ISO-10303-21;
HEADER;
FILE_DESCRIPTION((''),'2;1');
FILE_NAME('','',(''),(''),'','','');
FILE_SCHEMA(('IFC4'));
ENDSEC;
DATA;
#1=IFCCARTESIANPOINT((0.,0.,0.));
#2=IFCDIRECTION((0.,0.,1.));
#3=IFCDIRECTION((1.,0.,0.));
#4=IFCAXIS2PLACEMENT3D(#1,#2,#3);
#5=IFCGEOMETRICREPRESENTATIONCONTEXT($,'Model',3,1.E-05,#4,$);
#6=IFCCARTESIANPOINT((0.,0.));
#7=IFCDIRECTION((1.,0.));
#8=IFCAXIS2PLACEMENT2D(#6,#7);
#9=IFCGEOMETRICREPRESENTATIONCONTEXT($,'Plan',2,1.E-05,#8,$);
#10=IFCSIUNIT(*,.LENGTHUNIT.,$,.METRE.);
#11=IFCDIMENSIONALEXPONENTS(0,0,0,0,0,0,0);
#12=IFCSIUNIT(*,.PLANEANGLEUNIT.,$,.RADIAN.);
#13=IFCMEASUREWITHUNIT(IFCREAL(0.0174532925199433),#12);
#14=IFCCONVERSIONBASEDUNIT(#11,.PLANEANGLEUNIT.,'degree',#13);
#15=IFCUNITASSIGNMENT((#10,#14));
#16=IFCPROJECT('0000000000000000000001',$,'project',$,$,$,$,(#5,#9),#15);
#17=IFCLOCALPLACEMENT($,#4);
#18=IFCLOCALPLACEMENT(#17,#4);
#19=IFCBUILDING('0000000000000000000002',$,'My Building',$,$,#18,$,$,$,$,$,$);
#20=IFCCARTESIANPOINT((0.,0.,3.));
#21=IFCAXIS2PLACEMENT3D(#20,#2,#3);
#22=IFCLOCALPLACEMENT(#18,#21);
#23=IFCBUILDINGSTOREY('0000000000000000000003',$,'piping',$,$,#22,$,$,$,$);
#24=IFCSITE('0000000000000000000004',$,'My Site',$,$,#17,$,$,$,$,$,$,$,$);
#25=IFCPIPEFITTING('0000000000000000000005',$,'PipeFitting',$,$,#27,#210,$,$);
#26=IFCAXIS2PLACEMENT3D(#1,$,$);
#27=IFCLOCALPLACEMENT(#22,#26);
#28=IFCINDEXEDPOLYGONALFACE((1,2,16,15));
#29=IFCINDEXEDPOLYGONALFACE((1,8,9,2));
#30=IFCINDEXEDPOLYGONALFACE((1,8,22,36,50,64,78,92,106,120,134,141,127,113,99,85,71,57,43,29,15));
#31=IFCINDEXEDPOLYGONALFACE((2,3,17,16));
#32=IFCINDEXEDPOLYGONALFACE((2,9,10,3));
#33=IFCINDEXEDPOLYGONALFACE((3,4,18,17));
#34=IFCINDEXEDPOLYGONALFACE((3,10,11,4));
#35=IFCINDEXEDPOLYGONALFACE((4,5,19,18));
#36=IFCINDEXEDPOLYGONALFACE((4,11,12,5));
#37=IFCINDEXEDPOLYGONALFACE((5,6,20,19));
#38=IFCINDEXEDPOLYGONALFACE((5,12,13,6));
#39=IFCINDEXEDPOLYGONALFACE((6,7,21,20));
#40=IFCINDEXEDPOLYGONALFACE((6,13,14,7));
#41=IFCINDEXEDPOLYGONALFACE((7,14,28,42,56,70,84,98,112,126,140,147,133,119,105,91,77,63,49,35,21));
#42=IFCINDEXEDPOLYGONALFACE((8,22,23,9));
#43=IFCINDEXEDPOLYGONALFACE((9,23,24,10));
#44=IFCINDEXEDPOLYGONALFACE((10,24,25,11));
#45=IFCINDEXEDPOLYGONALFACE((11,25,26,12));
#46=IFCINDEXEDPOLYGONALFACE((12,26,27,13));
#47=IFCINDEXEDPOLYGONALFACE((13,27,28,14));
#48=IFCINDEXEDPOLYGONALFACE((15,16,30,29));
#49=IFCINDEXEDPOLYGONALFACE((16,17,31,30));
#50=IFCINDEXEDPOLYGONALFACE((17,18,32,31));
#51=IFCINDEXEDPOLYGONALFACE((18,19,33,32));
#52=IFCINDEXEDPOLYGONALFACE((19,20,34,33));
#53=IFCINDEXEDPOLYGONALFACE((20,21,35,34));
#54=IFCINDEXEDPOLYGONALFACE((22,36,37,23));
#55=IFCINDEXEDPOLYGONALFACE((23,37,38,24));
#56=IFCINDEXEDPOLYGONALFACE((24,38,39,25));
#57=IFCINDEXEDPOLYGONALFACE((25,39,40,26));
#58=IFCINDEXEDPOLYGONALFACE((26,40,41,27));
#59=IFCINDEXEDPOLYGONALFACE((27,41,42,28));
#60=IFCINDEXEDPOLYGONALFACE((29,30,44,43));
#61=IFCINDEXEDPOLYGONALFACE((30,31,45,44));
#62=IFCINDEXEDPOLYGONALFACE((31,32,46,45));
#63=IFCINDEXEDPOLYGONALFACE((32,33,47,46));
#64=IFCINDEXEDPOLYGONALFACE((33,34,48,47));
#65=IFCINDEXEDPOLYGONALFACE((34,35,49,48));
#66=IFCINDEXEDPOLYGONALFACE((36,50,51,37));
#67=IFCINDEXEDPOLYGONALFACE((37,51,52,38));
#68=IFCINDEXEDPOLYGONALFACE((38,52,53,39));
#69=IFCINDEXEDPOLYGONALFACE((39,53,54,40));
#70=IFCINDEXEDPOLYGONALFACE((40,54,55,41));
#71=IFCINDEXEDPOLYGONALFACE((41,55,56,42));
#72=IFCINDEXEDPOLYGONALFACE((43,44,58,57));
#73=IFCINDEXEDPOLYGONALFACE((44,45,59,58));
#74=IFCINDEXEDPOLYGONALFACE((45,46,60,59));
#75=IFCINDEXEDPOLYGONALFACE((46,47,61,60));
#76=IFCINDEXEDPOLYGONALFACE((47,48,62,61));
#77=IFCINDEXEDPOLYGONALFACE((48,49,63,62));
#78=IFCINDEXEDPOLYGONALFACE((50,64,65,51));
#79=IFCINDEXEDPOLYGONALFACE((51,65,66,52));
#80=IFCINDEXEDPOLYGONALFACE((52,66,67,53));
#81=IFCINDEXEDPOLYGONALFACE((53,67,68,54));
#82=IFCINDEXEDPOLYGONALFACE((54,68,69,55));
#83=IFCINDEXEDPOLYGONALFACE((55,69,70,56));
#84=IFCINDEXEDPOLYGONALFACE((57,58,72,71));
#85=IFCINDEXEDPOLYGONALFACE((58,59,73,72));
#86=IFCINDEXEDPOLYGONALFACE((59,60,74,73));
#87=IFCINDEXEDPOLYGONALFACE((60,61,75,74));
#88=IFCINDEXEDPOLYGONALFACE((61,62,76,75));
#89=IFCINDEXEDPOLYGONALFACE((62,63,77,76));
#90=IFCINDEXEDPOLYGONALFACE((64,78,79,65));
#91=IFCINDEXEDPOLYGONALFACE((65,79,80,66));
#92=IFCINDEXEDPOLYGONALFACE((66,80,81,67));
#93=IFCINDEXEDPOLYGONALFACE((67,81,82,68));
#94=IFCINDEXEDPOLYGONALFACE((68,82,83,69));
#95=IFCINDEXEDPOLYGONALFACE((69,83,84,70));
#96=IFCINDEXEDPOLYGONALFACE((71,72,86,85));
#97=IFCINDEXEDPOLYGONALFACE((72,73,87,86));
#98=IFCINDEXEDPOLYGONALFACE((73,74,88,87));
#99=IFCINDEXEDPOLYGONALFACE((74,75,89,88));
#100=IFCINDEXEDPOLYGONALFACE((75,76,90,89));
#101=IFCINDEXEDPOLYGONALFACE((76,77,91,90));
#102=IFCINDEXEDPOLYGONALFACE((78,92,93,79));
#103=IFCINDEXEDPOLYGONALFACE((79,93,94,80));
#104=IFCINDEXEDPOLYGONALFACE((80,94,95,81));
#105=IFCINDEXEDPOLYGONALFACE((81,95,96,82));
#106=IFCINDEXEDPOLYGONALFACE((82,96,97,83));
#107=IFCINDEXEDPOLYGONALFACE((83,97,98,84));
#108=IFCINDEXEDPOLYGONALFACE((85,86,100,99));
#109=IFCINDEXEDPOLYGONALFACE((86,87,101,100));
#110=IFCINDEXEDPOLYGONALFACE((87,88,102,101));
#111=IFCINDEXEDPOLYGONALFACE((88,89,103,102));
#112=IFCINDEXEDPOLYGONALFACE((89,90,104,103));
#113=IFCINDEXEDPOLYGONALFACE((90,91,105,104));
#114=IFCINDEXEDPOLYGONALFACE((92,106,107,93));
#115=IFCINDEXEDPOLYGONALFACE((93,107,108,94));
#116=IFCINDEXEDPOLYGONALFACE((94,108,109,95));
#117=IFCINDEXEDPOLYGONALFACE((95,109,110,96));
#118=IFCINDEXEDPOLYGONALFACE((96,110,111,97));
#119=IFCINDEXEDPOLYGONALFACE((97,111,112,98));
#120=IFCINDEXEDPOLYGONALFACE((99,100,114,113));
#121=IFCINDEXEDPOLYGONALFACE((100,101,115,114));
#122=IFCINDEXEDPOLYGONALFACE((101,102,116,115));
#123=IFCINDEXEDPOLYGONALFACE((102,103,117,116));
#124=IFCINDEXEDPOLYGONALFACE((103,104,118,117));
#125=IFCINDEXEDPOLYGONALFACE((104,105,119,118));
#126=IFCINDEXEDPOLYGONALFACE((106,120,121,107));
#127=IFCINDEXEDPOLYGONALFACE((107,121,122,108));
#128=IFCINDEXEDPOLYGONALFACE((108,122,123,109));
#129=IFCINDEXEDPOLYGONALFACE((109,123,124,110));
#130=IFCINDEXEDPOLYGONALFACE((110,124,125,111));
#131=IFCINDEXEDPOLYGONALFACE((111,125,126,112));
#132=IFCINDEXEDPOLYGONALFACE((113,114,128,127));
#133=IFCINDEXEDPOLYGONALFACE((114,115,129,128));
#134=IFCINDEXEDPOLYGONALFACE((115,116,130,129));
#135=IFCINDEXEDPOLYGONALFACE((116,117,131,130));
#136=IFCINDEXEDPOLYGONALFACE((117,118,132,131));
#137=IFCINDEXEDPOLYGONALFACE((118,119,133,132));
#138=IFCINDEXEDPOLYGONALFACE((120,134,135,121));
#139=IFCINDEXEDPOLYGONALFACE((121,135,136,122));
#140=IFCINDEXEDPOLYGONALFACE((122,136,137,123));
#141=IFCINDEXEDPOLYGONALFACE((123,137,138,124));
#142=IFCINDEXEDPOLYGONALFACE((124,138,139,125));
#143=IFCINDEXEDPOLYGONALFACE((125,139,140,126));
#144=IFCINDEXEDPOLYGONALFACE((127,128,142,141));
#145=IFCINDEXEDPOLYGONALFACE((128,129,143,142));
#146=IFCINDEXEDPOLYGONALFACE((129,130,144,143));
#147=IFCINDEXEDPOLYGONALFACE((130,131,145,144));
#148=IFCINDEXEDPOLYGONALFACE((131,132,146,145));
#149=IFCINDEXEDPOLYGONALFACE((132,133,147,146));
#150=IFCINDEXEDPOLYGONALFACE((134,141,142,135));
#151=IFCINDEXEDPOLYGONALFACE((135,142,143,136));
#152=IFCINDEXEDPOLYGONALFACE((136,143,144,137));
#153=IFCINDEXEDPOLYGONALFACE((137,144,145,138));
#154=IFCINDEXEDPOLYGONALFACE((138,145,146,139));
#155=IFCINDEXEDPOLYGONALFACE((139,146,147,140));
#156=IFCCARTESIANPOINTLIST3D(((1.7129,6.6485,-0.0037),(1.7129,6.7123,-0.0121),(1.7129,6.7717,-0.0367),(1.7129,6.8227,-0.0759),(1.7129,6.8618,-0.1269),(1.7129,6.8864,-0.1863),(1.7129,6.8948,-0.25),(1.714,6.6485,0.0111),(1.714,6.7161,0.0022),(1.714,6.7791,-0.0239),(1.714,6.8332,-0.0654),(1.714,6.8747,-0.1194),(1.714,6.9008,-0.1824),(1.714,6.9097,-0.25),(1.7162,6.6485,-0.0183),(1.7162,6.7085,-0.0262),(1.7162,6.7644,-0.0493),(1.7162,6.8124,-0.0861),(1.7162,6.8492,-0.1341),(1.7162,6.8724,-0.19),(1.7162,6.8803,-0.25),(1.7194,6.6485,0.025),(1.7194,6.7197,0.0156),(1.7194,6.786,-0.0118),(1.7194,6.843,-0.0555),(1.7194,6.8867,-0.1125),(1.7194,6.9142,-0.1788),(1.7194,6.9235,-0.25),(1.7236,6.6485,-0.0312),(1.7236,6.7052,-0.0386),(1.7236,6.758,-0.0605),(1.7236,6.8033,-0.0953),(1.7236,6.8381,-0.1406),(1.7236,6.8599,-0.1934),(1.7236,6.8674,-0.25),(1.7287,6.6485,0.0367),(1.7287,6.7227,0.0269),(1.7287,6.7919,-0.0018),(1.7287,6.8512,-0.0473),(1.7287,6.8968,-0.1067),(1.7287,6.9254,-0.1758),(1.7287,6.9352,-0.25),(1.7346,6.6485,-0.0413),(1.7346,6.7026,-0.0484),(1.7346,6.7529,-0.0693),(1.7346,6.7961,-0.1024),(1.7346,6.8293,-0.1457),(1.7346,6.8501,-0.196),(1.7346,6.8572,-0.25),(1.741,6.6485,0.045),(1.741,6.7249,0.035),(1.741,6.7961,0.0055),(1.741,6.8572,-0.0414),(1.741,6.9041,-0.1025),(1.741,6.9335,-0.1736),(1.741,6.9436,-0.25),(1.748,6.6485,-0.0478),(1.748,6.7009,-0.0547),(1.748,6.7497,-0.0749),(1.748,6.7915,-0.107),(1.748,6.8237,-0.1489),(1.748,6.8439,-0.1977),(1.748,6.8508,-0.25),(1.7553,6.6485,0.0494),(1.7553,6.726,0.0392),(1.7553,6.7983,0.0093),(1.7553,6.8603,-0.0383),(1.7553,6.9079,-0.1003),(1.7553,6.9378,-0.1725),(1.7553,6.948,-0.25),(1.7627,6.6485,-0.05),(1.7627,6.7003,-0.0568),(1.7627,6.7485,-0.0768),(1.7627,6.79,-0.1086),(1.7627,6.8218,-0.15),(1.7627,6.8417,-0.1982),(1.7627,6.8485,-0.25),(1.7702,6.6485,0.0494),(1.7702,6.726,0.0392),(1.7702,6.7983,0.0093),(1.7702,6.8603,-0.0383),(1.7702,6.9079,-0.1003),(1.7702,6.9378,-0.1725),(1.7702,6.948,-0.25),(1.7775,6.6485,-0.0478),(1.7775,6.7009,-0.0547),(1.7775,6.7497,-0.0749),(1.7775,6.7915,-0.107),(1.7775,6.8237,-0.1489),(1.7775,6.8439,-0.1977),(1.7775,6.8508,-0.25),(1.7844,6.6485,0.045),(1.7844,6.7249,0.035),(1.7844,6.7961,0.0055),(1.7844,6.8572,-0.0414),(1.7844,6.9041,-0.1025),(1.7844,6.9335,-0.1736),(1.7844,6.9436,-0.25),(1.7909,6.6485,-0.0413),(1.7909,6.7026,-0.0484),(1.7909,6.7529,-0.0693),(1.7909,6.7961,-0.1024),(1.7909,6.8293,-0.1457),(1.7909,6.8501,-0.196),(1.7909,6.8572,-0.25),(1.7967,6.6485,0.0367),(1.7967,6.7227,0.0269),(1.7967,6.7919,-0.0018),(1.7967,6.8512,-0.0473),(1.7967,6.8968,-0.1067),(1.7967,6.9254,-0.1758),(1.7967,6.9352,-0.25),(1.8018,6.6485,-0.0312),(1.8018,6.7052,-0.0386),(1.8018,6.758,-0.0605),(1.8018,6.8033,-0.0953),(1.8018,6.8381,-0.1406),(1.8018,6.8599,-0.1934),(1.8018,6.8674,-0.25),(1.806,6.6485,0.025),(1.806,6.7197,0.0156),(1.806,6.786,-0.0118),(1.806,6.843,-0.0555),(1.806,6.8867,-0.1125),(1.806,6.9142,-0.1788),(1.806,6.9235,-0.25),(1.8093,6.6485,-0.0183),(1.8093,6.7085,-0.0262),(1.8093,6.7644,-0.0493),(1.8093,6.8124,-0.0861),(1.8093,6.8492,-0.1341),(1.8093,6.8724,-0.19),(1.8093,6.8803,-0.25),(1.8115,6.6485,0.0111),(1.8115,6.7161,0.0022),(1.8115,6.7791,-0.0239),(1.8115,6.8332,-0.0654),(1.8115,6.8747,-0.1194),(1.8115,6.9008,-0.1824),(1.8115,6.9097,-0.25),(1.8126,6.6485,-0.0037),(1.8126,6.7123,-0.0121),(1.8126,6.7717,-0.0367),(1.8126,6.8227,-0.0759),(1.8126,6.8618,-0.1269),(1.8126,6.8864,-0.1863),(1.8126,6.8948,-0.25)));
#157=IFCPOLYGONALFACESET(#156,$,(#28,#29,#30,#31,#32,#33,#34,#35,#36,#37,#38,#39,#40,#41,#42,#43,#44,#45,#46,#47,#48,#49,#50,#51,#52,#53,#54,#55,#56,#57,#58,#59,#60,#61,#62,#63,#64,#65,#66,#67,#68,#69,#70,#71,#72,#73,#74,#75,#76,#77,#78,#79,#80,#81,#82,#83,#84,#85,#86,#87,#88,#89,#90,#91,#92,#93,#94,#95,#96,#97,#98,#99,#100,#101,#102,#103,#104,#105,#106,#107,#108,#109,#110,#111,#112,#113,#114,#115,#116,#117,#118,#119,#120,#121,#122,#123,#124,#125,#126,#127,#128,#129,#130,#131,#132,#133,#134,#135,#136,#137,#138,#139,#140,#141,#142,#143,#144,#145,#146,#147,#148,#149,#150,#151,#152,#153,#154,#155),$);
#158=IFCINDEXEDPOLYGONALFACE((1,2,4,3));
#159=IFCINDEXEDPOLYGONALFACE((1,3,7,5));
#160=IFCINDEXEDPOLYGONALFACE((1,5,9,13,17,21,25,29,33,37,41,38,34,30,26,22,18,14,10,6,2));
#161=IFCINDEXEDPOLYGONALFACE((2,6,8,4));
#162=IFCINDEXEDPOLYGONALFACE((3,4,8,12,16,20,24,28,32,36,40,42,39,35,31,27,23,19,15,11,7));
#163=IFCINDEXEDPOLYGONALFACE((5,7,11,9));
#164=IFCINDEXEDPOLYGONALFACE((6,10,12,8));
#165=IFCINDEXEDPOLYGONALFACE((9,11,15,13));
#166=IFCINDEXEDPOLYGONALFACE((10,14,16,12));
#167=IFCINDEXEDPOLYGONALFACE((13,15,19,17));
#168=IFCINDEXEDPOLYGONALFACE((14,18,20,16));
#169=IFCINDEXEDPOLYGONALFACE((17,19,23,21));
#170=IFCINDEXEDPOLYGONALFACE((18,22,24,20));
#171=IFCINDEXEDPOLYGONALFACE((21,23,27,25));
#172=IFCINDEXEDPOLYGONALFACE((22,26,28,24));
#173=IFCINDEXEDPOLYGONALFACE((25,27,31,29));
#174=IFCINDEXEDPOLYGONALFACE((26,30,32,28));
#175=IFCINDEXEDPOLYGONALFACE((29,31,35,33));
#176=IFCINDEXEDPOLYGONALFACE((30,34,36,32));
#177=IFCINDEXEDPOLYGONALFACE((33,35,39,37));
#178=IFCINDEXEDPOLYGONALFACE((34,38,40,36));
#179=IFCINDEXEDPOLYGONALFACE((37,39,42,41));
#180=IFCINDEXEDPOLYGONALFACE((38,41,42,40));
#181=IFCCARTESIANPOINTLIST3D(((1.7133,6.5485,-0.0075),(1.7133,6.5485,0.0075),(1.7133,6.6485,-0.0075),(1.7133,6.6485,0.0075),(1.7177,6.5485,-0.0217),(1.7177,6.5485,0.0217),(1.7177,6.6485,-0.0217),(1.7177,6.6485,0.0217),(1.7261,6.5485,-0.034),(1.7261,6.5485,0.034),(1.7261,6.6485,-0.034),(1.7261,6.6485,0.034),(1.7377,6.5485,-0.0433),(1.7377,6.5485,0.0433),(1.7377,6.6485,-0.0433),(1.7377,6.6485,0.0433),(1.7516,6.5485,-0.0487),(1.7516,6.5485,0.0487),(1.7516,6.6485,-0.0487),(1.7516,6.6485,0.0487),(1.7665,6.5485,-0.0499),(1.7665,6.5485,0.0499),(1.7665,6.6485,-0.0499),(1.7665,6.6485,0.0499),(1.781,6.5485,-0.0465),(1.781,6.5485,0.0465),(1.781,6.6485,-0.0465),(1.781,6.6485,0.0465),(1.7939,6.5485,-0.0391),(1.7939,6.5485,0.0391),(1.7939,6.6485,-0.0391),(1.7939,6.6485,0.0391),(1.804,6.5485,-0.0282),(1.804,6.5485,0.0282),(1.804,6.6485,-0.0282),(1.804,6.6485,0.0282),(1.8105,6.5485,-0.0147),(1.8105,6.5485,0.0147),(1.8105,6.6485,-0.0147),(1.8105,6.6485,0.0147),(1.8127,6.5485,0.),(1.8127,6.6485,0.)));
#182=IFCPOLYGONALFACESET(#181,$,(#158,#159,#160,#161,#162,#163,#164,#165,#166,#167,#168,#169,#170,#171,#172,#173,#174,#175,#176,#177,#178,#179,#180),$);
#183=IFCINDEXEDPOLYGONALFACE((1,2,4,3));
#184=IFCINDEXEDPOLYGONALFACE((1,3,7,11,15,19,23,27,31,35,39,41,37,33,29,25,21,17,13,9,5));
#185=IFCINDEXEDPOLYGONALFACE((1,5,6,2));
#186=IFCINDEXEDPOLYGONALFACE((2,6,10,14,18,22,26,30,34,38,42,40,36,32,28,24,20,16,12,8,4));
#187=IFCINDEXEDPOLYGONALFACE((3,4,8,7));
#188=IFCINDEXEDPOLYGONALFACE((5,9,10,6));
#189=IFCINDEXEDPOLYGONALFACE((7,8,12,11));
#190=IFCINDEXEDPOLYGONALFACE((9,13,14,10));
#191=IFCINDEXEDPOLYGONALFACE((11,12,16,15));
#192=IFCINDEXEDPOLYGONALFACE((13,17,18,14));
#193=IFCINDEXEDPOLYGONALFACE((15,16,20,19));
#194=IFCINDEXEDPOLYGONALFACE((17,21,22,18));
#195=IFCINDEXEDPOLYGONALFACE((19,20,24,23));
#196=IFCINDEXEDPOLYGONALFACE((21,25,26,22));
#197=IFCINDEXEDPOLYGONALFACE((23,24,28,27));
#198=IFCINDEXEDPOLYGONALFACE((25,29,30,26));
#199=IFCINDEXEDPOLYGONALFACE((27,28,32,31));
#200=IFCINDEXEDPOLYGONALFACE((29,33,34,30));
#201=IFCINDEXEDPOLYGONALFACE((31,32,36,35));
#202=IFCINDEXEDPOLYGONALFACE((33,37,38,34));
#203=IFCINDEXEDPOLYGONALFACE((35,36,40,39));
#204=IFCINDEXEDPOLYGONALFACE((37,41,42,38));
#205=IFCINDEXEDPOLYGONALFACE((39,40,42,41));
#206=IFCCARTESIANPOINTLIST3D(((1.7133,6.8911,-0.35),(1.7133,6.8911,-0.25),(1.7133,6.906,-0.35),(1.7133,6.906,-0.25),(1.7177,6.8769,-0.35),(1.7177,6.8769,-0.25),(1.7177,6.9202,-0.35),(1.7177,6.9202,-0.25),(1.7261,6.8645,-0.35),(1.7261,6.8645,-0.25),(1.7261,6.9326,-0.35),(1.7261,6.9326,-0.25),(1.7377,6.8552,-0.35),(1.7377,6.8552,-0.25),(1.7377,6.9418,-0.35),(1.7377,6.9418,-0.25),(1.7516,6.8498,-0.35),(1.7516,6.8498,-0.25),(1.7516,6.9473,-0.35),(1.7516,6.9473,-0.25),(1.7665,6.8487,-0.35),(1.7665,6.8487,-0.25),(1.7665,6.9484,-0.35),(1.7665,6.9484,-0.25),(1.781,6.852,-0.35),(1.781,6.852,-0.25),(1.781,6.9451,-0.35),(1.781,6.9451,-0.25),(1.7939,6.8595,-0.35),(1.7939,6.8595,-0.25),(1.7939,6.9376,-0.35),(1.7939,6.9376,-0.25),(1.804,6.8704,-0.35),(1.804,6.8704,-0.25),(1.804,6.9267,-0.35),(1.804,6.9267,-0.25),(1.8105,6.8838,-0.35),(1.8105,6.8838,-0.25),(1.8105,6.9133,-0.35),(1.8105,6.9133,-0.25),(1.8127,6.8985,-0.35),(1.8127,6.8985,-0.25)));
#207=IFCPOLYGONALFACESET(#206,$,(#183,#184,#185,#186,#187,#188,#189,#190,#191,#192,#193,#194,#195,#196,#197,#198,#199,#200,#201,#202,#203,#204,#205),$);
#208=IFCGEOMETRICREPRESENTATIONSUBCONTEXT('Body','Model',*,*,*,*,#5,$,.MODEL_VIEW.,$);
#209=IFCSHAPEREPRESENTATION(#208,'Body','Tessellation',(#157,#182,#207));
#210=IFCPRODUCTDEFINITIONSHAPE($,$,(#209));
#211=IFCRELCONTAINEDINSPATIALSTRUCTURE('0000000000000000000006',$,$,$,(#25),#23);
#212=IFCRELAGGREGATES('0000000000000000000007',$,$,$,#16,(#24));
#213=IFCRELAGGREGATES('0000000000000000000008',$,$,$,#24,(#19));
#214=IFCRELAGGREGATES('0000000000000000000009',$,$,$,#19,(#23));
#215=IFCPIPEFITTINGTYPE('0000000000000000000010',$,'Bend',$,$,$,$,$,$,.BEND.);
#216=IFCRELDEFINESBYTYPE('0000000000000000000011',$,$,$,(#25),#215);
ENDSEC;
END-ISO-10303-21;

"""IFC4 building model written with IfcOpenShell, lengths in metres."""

from ifc_helpers import new_model, entity, si_unit, converted_unit, frame, origin_with_axes, origin_2d_with_axis, place, context, subcontext, project, spatial, circle, extrude, source, transform, mapped, type_object, type_shapes, element, save


model = new_model("IFC4")

# Units and contexts
model_context = context("Model", 3, precision=1e-05, world=origin_with_axes())
plan_context = context("Plan", 2, precision=1e-05, world=origin_2d_with_axis())
body_context = subcontext(model_context, "Body", "Model", "MODEL_VIEW")
ifc_project = project(units=[si_unit("LENGTHUNIT", "METRE"), converted_unit("PLANEANGLEUNIT", "degree", entity("IfcReal", 0.0174532925199433), si_unit("PLANEANGLEUNIT", "RADIAN"), dimensions=[0, 0, 0, 0, 0, 0, 0])], contexts=[model_context, plan_context])

# Site, building, storey
site_placement = place(None, origin_with_axes())
site = spatial("IfcSite", under=ifc_project, at=site_placement, Name="My Site")
building_placement = place(site_placement, origin_with_axes())
building = spatial("IfcBuilding", under=site, at=building_placement, Name="My Building")
storey_placement = place(building_placement, frame((0.0, 0.0, 3.0), z_axis=(0.0, 0.0, 1.0), x_axis=(1.0, 0.0, 0.0)))
storey = spatial("IfcBuildingStorey", under=building, at=storey_placement, Name="piping")

# Pipe fitting
pipe_fitting_type = type_object("IfcPipeFittingType", Name="Bend", PredefinedType="BEND")
shared_shape = source(origin_with_axes(), body_context, "Body", "SolidModel", [
    entity("IfcSweptDiskSolid", entity("IfcIndexedPolyCurve", entity("IfcCartesianPointList3D", [[0.0, 0.0, -0.1], [0.0, -0.0732, -0.2768], [0.0, -0.25, -0.35]]), [entity("IfcArcIndex", [1, 2, 3])]), 0.05),
    extrude(circle(Radius=0.05), origin_with_axes(), (0.0, 0.0, -1.0), 0.1),
    extrude(circle(Radius=0.05), frame((0.0, -0.25, -0.35), z_axis=(0.0, -1.0, 0.0), x_axis=(1.0, 0.0, 0.0)), (0.0, 0.0, 1.0), 0.1),
])
type_shapes(pipe_fitting_type, [shared_shape])
for number, where, z_axis, x_axis, name in (
    (1, (1.7627, 6.5485, 0.0), (0.0, -1.0, 0.0), (1.0, 0.0, 0.0), "PipeFitting"),
):
    element("IfcPipeFitting", number, at=place(storey_placement, frame(where, z_axis=z_axis, x_axis=x_axis)), inside=storey, type_object=pipe_fitting_type, Name=name, context=body_context, shape_type="MappedRepresentation", body=[
        mapped(shared_shape, transform((0.0, 0.0, 0.0), x_axis=(1.0, 0.0, 0.0), y_axis=(0.0, 1.0, 0.0), z_axis=(0.0, 0.0, 1.0), scale=1.0)),
    ])

save(model, "model.ifc")
